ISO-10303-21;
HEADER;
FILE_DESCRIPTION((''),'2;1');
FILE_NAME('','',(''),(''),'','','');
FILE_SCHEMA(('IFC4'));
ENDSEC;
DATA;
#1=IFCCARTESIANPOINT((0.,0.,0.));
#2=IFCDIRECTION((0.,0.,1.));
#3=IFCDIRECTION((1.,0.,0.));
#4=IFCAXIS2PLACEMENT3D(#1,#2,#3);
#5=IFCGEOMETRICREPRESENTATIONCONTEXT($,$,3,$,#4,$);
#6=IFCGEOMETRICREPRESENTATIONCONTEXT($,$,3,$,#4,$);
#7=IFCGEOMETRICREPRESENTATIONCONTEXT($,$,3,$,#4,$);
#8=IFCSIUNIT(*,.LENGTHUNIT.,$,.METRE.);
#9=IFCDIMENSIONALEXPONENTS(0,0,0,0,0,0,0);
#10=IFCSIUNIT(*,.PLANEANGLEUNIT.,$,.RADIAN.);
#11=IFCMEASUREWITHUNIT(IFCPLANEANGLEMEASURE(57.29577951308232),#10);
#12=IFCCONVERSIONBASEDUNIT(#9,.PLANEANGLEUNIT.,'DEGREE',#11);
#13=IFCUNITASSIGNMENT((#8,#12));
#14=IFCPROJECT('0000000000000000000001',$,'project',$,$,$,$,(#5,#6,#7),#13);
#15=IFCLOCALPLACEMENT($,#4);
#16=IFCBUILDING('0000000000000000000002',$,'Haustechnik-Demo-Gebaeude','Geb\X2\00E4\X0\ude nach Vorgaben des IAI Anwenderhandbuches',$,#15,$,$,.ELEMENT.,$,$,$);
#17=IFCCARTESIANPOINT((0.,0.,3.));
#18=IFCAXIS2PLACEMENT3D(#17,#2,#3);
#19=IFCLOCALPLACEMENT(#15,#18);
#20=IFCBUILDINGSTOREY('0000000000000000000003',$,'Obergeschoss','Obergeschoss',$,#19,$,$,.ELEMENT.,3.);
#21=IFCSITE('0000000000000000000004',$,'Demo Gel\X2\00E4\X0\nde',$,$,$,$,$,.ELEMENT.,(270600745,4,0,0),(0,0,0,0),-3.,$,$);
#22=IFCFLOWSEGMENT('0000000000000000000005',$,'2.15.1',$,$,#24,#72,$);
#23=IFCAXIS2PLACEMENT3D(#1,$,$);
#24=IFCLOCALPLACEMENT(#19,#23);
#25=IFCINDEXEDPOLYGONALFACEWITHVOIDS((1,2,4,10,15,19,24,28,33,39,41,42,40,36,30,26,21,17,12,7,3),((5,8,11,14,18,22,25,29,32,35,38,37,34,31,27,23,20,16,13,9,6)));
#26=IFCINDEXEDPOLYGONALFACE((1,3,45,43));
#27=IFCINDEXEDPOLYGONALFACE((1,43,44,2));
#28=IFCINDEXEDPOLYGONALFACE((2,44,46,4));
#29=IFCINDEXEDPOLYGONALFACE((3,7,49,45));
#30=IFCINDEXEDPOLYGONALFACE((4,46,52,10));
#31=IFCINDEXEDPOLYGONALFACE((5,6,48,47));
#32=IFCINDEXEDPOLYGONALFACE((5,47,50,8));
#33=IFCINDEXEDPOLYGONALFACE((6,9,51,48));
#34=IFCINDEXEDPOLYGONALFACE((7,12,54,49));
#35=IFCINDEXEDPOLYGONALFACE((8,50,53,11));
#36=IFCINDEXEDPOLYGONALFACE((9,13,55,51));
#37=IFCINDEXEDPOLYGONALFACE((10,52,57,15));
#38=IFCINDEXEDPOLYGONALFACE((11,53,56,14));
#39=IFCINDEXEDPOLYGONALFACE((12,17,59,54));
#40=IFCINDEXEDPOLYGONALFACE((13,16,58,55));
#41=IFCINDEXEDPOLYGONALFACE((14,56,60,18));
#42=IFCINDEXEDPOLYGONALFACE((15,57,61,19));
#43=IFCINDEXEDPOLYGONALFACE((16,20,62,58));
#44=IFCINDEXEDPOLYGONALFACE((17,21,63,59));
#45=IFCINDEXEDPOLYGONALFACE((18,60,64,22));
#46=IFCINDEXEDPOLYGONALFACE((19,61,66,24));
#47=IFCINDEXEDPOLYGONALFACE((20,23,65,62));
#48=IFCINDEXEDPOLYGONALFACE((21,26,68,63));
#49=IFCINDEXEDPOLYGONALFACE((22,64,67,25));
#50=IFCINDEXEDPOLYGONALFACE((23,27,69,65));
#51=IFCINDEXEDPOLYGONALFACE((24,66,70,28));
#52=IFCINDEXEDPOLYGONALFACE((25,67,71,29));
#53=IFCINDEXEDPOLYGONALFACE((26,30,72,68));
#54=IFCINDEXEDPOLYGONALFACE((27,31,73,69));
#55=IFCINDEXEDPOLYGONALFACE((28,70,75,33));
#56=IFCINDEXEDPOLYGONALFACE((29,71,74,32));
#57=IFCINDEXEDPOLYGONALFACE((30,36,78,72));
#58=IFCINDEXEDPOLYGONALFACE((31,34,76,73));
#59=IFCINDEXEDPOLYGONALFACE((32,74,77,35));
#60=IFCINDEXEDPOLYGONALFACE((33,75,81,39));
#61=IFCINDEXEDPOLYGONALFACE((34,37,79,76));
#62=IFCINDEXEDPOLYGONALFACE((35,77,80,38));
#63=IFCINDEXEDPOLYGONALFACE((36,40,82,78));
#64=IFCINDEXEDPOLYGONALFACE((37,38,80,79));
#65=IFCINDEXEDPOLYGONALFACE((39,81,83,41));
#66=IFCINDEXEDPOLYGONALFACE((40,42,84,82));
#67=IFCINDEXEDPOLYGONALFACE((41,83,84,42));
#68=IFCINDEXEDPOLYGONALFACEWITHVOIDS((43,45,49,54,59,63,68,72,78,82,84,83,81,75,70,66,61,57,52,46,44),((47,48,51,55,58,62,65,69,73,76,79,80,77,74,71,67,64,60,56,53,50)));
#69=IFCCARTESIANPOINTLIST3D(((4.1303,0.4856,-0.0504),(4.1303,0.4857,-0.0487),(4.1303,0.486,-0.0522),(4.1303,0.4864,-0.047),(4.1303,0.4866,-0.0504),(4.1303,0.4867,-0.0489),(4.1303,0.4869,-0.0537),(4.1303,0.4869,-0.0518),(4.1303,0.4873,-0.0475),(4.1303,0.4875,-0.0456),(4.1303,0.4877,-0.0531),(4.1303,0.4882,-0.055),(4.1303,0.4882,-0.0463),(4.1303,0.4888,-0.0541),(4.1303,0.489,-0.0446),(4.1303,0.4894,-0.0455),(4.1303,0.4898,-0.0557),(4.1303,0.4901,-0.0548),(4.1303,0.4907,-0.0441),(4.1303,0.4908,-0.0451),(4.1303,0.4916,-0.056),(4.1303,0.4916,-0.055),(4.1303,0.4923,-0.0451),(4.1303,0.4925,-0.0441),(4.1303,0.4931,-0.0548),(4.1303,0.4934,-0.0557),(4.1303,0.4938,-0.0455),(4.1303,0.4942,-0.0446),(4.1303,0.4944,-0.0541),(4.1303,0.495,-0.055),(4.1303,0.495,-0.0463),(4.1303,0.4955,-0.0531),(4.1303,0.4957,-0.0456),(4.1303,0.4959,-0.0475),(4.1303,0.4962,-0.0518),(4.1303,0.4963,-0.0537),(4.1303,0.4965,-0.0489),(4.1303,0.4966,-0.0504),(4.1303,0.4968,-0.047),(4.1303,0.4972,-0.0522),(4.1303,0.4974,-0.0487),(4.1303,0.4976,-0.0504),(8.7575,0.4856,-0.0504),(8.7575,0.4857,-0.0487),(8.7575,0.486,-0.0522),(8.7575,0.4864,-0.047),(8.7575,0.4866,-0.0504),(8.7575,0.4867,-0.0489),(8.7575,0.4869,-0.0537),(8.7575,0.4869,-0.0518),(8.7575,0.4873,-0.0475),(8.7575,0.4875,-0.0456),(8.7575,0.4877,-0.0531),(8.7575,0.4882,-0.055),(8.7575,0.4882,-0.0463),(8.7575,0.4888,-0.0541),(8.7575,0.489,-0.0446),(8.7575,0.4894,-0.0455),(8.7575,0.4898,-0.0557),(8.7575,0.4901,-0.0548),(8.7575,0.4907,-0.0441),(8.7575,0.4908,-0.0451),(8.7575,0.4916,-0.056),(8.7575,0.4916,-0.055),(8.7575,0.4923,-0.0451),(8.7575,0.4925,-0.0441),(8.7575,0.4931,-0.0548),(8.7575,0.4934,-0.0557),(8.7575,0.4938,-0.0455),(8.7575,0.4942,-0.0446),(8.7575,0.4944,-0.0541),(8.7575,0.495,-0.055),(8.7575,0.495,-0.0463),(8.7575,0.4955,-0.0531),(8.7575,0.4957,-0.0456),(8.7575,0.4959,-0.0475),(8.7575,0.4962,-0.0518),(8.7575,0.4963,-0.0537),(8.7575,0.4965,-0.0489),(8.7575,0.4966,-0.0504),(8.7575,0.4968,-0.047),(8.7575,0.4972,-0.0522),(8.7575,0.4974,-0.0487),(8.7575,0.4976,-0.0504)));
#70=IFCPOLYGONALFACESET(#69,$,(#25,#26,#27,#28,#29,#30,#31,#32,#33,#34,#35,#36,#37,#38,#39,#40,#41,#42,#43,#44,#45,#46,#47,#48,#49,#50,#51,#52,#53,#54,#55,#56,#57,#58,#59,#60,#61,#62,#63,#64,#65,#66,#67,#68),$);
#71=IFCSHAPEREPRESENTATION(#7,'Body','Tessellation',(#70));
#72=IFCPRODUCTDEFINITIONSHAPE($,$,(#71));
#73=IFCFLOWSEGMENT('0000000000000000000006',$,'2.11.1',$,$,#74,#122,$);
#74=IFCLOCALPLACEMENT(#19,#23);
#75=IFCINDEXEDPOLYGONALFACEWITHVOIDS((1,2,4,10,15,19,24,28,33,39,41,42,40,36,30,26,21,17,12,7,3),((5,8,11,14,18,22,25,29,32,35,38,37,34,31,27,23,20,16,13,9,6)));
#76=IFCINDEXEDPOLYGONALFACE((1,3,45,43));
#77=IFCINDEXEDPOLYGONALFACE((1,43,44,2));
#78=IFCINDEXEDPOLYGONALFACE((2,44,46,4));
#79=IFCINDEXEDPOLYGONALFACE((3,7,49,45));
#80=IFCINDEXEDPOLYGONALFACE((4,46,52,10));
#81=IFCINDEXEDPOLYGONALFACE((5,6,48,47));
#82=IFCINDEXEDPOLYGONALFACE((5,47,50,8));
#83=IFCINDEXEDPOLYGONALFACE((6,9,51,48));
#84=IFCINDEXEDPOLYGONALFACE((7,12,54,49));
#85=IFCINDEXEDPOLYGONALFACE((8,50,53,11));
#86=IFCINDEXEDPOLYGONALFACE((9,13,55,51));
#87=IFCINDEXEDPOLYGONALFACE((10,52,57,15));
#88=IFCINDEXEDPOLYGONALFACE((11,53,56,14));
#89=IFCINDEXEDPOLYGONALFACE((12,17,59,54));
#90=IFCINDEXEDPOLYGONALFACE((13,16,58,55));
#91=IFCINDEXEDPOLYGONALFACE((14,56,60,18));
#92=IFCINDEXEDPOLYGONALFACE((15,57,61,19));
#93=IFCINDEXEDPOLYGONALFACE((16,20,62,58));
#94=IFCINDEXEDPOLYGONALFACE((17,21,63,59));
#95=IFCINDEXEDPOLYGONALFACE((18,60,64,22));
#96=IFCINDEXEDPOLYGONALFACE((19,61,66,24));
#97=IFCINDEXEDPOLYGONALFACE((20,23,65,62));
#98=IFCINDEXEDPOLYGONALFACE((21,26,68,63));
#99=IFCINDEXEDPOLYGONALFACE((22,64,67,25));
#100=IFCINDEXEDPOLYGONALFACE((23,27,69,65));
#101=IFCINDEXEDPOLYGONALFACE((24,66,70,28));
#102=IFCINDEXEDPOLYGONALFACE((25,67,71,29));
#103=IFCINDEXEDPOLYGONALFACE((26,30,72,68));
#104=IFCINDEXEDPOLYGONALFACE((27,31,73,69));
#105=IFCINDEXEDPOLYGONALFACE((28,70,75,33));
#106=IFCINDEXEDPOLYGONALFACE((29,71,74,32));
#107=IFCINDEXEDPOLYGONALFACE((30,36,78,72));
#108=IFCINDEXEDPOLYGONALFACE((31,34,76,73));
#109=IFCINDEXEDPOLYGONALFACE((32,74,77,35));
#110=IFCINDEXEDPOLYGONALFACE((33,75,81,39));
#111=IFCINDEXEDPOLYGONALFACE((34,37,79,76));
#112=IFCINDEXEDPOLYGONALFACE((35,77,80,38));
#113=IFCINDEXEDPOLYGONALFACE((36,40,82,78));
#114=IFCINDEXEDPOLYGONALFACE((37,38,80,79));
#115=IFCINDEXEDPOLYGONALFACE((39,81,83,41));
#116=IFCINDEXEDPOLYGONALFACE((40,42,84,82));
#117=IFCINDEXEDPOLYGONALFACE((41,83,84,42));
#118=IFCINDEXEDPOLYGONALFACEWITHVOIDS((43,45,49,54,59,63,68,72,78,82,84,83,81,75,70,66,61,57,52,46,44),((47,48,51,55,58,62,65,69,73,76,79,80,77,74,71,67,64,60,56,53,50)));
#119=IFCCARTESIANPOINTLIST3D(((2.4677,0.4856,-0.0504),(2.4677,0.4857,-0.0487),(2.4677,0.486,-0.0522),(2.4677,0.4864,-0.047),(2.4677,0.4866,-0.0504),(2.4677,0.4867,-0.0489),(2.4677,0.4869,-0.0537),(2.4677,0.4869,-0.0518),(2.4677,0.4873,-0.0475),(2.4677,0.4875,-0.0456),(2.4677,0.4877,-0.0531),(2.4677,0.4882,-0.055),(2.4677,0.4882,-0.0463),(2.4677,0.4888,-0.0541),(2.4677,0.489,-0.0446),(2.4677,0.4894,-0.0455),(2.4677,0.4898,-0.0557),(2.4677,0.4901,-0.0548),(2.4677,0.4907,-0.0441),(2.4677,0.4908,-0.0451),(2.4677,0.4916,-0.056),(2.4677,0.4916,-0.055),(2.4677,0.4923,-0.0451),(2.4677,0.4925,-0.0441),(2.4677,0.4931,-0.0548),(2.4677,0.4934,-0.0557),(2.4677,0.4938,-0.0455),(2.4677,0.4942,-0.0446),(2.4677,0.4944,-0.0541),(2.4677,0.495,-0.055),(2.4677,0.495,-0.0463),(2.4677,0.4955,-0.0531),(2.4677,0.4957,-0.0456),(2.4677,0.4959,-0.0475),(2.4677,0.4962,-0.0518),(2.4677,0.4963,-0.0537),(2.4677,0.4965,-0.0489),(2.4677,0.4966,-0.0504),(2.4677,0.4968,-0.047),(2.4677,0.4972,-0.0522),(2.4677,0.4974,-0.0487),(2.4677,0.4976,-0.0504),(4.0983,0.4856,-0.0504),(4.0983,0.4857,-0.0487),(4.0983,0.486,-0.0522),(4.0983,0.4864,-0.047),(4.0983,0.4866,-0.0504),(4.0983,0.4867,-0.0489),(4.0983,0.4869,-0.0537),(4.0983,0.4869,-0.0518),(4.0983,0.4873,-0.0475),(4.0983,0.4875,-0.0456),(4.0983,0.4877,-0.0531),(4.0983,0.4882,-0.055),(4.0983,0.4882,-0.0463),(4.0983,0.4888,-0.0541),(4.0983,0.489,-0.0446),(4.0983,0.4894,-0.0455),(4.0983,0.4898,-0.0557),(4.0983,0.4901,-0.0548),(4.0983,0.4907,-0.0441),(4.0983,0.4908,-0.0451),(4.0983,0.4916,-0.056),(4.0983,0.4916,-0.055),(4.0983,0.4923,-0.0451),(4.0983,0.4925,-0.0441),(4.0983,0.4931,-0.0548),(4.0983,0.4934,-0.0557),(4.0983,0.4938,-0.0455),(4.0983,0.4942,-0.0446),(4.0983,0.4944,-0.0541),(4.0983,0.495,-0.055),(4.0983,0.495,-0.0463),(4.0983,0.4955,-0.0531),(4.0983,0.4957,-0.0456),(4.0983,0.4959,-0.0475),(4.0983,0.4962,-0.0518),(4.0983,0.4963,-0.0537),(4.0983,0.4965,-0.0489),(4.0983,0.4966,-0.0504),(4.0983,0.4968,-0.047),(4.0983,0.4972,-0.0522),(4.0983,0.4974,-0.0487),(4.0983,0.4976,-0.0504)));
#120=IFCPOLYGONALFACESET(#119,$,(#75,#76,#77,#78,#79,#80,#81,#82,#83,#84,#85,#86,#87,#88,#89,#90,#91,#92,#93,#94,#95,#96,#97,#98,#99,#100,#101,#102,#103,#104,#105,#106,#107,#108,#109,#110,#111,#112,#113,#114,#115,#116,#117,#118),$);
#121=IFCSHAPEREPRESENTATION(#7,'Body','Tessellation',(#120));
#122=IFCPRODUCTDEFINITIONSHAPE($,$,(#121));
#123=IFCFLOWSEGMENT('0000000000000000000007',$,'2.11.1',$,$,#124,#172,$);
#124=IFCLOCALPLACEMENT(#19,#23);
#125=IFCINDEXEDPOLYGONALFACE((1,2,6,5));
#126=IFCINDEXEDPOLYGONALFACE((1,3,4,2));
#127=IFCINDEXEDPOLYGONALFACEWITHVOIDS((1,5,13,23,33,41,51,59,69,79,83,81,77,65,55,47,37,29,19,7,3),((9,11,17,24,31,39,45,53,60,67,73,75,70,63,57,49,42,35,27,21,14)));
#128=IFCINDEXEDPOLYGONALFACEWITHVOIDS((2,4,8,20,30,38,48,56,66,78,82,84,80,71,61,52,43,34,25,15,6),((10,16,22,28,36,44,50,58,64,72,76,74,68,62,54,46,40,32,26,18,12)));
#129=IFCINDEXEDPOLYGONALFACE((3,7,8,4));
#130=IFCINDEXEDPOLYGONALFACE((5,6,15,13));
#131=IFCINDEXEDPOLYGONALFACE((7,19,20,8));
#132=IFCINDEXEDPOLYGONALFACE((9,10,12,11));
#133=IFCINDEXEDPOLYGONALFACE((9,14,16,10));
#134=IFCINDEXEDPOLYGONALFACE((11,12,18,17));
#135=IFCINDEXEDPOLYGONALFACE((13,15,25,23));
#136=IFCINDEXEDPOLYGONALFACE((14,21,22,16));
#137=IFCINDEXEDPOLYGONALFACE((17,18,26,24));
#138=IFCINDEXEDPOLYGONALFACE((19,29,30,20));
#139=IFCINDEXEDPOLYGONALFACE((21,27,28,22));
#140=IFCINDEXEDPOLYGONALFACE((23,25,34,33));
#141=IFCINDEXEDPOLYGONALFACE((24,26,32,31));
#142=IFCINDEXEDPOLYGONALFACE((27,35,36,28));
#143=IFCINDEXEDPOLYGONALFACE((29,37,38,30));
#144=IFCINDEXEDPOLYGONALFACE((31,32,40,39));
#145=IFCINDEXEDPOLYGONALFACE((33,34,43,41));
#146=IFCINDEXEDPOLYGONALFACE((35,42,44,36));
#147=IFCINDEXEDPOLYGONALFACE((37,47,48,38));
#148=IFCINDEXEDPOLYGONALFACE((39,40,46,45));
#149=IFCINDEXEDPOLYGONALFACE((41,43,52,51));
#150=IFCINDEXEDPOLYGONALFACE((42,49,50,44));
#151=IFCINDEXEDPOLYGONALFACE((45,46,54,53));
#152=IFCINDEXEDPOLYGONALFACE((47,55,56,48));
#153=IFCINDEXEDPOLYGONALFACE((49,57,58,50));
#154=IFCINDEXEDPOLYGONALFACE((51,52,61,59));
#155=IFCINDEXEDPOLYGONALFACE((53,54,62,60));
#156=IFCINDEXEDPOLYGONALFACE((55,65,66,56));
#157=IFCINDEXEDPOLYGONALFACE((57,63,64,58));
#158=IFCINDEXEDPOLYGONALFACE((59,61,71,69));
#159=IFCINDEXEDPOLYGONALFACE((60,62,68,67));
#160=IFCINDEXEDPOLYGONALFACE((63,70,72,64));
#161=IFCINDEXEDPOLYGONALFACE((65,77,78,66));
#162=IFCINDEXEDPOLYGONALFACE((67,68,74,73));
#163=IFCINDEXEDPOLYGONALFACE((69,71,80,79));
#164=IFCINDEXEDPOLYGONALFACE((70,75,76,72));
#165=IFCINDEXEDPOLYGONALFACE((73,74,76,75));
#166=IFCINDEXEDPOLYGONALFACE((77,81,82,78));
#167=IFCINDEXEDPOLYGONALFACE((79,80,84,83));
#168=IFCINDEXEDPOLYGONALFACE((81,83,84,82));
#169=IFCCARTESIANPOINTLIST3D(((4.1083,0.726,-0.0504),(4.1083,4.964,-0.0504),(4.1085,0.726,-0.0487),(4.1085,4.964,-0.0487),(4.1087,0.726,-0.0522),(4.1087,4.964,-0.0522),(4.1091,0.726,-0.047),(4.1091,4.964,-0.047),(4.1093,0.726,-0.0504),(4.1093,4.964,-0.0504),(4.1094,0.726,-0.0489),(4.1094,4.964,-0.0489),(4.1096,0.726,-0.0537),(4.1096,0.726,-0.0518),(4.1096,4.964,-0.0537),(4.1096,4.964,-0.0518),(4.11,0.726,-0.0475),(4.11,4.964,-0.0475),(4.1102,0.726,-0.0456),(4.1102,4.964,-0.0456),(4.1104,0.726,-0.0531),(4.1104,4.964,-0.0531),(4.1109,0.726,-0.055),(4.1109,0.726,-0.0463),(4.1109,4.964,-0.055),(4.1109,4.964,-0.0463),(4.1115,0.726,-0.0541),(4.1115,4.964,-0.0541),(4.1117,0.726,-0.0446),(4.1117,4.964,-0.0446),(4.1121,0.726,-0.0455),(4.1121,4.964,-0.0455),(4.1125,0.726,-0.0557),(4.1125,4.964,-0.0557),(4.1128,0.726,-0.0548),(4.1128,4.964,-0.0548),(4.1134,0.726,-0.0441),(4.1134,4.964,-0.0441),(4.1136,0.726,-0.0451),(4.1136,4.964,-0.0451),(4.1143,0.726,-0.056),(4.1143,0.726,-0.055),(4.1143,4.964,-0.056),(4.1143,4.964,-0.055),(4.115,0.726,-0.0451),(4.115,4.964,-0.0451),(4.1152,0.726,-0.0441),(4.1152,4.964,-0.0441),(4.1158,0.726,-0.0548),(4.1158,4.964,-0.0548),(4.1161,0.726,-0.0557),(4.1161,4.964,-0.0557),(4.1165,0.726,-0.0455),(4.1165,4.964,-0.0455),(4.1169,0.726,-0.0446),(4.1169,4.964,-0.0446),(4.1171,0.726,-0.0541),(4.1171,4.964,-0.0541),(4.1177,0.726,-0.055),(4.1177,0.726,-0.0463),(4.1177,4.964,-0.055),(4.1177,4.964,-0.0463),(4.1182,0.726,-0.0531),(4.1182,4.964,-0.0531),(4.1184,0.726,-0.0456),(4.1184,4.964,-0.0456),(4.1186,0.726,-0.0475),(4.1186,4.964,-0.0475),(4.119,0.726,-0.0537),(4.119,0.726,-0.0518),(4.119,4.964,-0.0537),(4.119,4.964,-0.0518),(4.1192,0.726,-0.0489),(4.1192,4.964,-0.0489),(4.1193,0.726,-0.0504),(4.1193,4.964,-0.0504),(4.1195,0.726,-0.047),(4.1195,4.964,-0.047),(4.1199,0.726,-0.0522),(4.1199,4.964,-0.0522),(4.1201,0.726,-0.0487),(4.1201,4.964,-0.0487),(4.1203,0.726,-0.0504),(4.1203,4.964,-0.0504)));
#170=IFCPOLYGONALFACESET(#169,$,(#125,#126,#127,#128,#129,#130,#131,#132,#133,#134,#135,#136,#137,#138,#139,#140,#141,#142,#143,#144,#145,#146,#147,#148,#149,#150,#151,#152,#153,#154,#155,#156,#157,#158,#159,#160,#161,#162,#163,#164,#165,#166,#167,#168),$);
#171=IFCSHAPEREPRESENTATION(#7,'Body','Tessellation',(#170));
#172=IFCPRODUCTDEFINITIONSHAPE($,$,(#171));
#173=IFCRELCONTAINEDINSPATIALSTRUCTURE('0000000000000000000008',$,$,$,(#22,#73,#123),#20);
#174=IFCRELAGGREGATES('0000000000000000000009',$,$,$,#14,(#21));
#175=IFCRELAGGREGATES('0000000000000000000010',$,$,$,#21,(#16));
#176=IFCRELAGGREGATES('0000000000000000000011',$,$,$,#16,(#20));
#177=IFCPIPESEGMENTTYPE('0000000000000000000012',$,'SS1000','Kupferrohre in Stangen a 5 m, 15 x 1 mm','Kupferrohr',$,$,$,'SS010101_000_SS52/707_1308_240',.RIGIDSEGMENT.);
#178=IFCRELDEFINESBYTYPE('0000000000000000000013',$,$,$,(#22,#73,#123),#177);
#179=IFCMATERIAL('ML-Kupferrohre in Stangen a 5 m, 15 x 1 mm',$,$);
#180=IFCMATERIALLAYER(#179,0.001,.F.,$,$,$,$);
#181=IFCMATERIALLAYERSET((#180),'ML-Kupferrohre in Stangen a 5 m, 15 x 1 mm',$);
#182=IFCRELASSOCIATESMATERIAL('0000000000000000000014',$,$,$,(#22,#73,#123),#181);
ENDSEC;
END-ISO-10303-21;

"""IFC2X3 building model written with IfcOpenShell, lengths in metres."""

from ifc_helpers import new_model, entity, si_unit, converted_unit, frame, origin_with_axes, origin_2d_with_axis, place, context, project, spatial, hollow_circle, extrude, material, layer, layer_set, layer_usage, type_object, element, save


model = new_model("IFC2X3")

# Units and contexts
context_of_model_1 = context(None, 3, world=origin_with_axes())
context_of_model_2 = context(None, 3, world=origin_with_axes())
context_of_model_3 = context(None, 3, world=origin_with_axes())
ifc_project = project(units=[si_unit("LENGTHUNIT", "METRE"), converted_unit("PLANEANGLEUNIT", "DEGREE", entity("IfcPlaneAngleMeasure", 57.29577951308232), si_unit("PLANEANGLEUNIT", "RADIAN"), dimensions=[0, 0, 0, 0, 0, 0, 0])], contexts=[context_of_model_1, context_of_model_2, context_of_model_3])

# Site, building, storey
site = spatial("IfcSite", under=ifc_project, Name="Demo Gelände", CompositionType="ELEMENT", RefLatitude=(270600745, 4, 0, 0), RefLongitude=(0, 0, 0, 0), RefElevation=-3.0)
building_placement = place(None, origin_with_axes())
building = spatial("IfcBuilding", under=site, at=building_placement, Name="Haustechnik-Demo-Gebaeude", Description="Gebäude nach Vorgaben des IAI Anwenderhandbuches", CompositionType="ELEMENT")
storey_placement = place(building_placement, frame((0.0, 0.0, 3.0), z_axis=(0.0, 0.0, 1.0), x_axis=(1.0, 0.0, 0.0)))
storey = spatial("IfcBuildingStorey", under=building, at=storey_placement, Name="Obergeschoss", Description="Obergeschoss", CompositionType="ELEMENT", Elevation=3.0)

# Flow segments
ifc_material = material(Name="ML-Kupferrohre in Stangen a 5 m, 15 x 1 mm")
ifc_layer = layer(ifc_material, 0.001, ventilated=False)
ifc_layer_set = layer_set([ifc_layer], Name="ML-Kupferrohre in Stangen a 5 m, 15 x 1 mm")
ifc_layer_usage = layer_usage(ifc_layer_set, "AXIS2", "POSITIVE", 0.0)
pipe_segment_type_1 = type_object("IfcPipeSegmentType", Name="SS1000", Description="Kupferrohre in Stangen a 5 m, 15 x 1 mm", ApplicableOccurrence="Kupferrohr", ElementType="SS010101_000_SS52/707_1308_240", PredefinedType="RIGIDSEGMENT")
flow_segment_1_placement = place(storey_placement, frame((8.7575, 0.4916, -0.05), z_axis=(-1.0, 0.0, 0.0), x_axis=(0.0, 0.0, -1.0)))
element("IfcFlowSegment", 1, at=flow_segment_1_placement, inside=storey, type_object=pipe_segment_type_1, material=ifc_layer_usage, Name="2.15.1", context=context_of_model_3, shape_type="SweptSolid", body=[
    extrude(hollow_circle(Radius=0.006, WallThickness=0.001, at=origin_2d_with_axis()), origin_with_axes(), (0.0, 0.0, 1.0), 4.6272),
])
flow_segment_2_placement = place(storey_placement, frame((4.0983, 0.4916, -0.05), z_axis=(-1.0, 0.0, 0.0), x_axis=(0.0, 0.0, -1.0)))
element("IfcFlowSegment", 2, at=flow_segment_2_placement, inside=storey, type_object=pipe_segment_type_1, material=ifc_layer_usage, Name="2.11.1", context=context_of_model_3, shape_type="SweptSolid", body=[
    extrude(hollow_circle(Radius=0.006, WallThickness=0.001, at=origin_2d_with_axis()), origin_with_axes(), (0.0, 0.0, 1.0), 1.6306),
])
flow_segment_3_placement = place(storey_placement, frame((4.1143, 4.964, -0.05), z_axis=(0.0, -1.0, 0.0), x_axis=(0.0, 0.0, -1.0)))
element("IfcFlowSegment", 3, at=flow_segment_3_placement, inside=storey, type_object=pipe_segment_type_1, material=ifc_layer_usage, Name="2.11.1", context=context_of_model_3, shape_type="SweptSolid", body=[
    extrude(hollow_circle(Radius=0.006, WallThickness=0.001, at=origin_2d_with_axis()), origin_with_axes(), (0.0, 0.0, 1.0), 4.238),
])

save(model, "model.ifc")
